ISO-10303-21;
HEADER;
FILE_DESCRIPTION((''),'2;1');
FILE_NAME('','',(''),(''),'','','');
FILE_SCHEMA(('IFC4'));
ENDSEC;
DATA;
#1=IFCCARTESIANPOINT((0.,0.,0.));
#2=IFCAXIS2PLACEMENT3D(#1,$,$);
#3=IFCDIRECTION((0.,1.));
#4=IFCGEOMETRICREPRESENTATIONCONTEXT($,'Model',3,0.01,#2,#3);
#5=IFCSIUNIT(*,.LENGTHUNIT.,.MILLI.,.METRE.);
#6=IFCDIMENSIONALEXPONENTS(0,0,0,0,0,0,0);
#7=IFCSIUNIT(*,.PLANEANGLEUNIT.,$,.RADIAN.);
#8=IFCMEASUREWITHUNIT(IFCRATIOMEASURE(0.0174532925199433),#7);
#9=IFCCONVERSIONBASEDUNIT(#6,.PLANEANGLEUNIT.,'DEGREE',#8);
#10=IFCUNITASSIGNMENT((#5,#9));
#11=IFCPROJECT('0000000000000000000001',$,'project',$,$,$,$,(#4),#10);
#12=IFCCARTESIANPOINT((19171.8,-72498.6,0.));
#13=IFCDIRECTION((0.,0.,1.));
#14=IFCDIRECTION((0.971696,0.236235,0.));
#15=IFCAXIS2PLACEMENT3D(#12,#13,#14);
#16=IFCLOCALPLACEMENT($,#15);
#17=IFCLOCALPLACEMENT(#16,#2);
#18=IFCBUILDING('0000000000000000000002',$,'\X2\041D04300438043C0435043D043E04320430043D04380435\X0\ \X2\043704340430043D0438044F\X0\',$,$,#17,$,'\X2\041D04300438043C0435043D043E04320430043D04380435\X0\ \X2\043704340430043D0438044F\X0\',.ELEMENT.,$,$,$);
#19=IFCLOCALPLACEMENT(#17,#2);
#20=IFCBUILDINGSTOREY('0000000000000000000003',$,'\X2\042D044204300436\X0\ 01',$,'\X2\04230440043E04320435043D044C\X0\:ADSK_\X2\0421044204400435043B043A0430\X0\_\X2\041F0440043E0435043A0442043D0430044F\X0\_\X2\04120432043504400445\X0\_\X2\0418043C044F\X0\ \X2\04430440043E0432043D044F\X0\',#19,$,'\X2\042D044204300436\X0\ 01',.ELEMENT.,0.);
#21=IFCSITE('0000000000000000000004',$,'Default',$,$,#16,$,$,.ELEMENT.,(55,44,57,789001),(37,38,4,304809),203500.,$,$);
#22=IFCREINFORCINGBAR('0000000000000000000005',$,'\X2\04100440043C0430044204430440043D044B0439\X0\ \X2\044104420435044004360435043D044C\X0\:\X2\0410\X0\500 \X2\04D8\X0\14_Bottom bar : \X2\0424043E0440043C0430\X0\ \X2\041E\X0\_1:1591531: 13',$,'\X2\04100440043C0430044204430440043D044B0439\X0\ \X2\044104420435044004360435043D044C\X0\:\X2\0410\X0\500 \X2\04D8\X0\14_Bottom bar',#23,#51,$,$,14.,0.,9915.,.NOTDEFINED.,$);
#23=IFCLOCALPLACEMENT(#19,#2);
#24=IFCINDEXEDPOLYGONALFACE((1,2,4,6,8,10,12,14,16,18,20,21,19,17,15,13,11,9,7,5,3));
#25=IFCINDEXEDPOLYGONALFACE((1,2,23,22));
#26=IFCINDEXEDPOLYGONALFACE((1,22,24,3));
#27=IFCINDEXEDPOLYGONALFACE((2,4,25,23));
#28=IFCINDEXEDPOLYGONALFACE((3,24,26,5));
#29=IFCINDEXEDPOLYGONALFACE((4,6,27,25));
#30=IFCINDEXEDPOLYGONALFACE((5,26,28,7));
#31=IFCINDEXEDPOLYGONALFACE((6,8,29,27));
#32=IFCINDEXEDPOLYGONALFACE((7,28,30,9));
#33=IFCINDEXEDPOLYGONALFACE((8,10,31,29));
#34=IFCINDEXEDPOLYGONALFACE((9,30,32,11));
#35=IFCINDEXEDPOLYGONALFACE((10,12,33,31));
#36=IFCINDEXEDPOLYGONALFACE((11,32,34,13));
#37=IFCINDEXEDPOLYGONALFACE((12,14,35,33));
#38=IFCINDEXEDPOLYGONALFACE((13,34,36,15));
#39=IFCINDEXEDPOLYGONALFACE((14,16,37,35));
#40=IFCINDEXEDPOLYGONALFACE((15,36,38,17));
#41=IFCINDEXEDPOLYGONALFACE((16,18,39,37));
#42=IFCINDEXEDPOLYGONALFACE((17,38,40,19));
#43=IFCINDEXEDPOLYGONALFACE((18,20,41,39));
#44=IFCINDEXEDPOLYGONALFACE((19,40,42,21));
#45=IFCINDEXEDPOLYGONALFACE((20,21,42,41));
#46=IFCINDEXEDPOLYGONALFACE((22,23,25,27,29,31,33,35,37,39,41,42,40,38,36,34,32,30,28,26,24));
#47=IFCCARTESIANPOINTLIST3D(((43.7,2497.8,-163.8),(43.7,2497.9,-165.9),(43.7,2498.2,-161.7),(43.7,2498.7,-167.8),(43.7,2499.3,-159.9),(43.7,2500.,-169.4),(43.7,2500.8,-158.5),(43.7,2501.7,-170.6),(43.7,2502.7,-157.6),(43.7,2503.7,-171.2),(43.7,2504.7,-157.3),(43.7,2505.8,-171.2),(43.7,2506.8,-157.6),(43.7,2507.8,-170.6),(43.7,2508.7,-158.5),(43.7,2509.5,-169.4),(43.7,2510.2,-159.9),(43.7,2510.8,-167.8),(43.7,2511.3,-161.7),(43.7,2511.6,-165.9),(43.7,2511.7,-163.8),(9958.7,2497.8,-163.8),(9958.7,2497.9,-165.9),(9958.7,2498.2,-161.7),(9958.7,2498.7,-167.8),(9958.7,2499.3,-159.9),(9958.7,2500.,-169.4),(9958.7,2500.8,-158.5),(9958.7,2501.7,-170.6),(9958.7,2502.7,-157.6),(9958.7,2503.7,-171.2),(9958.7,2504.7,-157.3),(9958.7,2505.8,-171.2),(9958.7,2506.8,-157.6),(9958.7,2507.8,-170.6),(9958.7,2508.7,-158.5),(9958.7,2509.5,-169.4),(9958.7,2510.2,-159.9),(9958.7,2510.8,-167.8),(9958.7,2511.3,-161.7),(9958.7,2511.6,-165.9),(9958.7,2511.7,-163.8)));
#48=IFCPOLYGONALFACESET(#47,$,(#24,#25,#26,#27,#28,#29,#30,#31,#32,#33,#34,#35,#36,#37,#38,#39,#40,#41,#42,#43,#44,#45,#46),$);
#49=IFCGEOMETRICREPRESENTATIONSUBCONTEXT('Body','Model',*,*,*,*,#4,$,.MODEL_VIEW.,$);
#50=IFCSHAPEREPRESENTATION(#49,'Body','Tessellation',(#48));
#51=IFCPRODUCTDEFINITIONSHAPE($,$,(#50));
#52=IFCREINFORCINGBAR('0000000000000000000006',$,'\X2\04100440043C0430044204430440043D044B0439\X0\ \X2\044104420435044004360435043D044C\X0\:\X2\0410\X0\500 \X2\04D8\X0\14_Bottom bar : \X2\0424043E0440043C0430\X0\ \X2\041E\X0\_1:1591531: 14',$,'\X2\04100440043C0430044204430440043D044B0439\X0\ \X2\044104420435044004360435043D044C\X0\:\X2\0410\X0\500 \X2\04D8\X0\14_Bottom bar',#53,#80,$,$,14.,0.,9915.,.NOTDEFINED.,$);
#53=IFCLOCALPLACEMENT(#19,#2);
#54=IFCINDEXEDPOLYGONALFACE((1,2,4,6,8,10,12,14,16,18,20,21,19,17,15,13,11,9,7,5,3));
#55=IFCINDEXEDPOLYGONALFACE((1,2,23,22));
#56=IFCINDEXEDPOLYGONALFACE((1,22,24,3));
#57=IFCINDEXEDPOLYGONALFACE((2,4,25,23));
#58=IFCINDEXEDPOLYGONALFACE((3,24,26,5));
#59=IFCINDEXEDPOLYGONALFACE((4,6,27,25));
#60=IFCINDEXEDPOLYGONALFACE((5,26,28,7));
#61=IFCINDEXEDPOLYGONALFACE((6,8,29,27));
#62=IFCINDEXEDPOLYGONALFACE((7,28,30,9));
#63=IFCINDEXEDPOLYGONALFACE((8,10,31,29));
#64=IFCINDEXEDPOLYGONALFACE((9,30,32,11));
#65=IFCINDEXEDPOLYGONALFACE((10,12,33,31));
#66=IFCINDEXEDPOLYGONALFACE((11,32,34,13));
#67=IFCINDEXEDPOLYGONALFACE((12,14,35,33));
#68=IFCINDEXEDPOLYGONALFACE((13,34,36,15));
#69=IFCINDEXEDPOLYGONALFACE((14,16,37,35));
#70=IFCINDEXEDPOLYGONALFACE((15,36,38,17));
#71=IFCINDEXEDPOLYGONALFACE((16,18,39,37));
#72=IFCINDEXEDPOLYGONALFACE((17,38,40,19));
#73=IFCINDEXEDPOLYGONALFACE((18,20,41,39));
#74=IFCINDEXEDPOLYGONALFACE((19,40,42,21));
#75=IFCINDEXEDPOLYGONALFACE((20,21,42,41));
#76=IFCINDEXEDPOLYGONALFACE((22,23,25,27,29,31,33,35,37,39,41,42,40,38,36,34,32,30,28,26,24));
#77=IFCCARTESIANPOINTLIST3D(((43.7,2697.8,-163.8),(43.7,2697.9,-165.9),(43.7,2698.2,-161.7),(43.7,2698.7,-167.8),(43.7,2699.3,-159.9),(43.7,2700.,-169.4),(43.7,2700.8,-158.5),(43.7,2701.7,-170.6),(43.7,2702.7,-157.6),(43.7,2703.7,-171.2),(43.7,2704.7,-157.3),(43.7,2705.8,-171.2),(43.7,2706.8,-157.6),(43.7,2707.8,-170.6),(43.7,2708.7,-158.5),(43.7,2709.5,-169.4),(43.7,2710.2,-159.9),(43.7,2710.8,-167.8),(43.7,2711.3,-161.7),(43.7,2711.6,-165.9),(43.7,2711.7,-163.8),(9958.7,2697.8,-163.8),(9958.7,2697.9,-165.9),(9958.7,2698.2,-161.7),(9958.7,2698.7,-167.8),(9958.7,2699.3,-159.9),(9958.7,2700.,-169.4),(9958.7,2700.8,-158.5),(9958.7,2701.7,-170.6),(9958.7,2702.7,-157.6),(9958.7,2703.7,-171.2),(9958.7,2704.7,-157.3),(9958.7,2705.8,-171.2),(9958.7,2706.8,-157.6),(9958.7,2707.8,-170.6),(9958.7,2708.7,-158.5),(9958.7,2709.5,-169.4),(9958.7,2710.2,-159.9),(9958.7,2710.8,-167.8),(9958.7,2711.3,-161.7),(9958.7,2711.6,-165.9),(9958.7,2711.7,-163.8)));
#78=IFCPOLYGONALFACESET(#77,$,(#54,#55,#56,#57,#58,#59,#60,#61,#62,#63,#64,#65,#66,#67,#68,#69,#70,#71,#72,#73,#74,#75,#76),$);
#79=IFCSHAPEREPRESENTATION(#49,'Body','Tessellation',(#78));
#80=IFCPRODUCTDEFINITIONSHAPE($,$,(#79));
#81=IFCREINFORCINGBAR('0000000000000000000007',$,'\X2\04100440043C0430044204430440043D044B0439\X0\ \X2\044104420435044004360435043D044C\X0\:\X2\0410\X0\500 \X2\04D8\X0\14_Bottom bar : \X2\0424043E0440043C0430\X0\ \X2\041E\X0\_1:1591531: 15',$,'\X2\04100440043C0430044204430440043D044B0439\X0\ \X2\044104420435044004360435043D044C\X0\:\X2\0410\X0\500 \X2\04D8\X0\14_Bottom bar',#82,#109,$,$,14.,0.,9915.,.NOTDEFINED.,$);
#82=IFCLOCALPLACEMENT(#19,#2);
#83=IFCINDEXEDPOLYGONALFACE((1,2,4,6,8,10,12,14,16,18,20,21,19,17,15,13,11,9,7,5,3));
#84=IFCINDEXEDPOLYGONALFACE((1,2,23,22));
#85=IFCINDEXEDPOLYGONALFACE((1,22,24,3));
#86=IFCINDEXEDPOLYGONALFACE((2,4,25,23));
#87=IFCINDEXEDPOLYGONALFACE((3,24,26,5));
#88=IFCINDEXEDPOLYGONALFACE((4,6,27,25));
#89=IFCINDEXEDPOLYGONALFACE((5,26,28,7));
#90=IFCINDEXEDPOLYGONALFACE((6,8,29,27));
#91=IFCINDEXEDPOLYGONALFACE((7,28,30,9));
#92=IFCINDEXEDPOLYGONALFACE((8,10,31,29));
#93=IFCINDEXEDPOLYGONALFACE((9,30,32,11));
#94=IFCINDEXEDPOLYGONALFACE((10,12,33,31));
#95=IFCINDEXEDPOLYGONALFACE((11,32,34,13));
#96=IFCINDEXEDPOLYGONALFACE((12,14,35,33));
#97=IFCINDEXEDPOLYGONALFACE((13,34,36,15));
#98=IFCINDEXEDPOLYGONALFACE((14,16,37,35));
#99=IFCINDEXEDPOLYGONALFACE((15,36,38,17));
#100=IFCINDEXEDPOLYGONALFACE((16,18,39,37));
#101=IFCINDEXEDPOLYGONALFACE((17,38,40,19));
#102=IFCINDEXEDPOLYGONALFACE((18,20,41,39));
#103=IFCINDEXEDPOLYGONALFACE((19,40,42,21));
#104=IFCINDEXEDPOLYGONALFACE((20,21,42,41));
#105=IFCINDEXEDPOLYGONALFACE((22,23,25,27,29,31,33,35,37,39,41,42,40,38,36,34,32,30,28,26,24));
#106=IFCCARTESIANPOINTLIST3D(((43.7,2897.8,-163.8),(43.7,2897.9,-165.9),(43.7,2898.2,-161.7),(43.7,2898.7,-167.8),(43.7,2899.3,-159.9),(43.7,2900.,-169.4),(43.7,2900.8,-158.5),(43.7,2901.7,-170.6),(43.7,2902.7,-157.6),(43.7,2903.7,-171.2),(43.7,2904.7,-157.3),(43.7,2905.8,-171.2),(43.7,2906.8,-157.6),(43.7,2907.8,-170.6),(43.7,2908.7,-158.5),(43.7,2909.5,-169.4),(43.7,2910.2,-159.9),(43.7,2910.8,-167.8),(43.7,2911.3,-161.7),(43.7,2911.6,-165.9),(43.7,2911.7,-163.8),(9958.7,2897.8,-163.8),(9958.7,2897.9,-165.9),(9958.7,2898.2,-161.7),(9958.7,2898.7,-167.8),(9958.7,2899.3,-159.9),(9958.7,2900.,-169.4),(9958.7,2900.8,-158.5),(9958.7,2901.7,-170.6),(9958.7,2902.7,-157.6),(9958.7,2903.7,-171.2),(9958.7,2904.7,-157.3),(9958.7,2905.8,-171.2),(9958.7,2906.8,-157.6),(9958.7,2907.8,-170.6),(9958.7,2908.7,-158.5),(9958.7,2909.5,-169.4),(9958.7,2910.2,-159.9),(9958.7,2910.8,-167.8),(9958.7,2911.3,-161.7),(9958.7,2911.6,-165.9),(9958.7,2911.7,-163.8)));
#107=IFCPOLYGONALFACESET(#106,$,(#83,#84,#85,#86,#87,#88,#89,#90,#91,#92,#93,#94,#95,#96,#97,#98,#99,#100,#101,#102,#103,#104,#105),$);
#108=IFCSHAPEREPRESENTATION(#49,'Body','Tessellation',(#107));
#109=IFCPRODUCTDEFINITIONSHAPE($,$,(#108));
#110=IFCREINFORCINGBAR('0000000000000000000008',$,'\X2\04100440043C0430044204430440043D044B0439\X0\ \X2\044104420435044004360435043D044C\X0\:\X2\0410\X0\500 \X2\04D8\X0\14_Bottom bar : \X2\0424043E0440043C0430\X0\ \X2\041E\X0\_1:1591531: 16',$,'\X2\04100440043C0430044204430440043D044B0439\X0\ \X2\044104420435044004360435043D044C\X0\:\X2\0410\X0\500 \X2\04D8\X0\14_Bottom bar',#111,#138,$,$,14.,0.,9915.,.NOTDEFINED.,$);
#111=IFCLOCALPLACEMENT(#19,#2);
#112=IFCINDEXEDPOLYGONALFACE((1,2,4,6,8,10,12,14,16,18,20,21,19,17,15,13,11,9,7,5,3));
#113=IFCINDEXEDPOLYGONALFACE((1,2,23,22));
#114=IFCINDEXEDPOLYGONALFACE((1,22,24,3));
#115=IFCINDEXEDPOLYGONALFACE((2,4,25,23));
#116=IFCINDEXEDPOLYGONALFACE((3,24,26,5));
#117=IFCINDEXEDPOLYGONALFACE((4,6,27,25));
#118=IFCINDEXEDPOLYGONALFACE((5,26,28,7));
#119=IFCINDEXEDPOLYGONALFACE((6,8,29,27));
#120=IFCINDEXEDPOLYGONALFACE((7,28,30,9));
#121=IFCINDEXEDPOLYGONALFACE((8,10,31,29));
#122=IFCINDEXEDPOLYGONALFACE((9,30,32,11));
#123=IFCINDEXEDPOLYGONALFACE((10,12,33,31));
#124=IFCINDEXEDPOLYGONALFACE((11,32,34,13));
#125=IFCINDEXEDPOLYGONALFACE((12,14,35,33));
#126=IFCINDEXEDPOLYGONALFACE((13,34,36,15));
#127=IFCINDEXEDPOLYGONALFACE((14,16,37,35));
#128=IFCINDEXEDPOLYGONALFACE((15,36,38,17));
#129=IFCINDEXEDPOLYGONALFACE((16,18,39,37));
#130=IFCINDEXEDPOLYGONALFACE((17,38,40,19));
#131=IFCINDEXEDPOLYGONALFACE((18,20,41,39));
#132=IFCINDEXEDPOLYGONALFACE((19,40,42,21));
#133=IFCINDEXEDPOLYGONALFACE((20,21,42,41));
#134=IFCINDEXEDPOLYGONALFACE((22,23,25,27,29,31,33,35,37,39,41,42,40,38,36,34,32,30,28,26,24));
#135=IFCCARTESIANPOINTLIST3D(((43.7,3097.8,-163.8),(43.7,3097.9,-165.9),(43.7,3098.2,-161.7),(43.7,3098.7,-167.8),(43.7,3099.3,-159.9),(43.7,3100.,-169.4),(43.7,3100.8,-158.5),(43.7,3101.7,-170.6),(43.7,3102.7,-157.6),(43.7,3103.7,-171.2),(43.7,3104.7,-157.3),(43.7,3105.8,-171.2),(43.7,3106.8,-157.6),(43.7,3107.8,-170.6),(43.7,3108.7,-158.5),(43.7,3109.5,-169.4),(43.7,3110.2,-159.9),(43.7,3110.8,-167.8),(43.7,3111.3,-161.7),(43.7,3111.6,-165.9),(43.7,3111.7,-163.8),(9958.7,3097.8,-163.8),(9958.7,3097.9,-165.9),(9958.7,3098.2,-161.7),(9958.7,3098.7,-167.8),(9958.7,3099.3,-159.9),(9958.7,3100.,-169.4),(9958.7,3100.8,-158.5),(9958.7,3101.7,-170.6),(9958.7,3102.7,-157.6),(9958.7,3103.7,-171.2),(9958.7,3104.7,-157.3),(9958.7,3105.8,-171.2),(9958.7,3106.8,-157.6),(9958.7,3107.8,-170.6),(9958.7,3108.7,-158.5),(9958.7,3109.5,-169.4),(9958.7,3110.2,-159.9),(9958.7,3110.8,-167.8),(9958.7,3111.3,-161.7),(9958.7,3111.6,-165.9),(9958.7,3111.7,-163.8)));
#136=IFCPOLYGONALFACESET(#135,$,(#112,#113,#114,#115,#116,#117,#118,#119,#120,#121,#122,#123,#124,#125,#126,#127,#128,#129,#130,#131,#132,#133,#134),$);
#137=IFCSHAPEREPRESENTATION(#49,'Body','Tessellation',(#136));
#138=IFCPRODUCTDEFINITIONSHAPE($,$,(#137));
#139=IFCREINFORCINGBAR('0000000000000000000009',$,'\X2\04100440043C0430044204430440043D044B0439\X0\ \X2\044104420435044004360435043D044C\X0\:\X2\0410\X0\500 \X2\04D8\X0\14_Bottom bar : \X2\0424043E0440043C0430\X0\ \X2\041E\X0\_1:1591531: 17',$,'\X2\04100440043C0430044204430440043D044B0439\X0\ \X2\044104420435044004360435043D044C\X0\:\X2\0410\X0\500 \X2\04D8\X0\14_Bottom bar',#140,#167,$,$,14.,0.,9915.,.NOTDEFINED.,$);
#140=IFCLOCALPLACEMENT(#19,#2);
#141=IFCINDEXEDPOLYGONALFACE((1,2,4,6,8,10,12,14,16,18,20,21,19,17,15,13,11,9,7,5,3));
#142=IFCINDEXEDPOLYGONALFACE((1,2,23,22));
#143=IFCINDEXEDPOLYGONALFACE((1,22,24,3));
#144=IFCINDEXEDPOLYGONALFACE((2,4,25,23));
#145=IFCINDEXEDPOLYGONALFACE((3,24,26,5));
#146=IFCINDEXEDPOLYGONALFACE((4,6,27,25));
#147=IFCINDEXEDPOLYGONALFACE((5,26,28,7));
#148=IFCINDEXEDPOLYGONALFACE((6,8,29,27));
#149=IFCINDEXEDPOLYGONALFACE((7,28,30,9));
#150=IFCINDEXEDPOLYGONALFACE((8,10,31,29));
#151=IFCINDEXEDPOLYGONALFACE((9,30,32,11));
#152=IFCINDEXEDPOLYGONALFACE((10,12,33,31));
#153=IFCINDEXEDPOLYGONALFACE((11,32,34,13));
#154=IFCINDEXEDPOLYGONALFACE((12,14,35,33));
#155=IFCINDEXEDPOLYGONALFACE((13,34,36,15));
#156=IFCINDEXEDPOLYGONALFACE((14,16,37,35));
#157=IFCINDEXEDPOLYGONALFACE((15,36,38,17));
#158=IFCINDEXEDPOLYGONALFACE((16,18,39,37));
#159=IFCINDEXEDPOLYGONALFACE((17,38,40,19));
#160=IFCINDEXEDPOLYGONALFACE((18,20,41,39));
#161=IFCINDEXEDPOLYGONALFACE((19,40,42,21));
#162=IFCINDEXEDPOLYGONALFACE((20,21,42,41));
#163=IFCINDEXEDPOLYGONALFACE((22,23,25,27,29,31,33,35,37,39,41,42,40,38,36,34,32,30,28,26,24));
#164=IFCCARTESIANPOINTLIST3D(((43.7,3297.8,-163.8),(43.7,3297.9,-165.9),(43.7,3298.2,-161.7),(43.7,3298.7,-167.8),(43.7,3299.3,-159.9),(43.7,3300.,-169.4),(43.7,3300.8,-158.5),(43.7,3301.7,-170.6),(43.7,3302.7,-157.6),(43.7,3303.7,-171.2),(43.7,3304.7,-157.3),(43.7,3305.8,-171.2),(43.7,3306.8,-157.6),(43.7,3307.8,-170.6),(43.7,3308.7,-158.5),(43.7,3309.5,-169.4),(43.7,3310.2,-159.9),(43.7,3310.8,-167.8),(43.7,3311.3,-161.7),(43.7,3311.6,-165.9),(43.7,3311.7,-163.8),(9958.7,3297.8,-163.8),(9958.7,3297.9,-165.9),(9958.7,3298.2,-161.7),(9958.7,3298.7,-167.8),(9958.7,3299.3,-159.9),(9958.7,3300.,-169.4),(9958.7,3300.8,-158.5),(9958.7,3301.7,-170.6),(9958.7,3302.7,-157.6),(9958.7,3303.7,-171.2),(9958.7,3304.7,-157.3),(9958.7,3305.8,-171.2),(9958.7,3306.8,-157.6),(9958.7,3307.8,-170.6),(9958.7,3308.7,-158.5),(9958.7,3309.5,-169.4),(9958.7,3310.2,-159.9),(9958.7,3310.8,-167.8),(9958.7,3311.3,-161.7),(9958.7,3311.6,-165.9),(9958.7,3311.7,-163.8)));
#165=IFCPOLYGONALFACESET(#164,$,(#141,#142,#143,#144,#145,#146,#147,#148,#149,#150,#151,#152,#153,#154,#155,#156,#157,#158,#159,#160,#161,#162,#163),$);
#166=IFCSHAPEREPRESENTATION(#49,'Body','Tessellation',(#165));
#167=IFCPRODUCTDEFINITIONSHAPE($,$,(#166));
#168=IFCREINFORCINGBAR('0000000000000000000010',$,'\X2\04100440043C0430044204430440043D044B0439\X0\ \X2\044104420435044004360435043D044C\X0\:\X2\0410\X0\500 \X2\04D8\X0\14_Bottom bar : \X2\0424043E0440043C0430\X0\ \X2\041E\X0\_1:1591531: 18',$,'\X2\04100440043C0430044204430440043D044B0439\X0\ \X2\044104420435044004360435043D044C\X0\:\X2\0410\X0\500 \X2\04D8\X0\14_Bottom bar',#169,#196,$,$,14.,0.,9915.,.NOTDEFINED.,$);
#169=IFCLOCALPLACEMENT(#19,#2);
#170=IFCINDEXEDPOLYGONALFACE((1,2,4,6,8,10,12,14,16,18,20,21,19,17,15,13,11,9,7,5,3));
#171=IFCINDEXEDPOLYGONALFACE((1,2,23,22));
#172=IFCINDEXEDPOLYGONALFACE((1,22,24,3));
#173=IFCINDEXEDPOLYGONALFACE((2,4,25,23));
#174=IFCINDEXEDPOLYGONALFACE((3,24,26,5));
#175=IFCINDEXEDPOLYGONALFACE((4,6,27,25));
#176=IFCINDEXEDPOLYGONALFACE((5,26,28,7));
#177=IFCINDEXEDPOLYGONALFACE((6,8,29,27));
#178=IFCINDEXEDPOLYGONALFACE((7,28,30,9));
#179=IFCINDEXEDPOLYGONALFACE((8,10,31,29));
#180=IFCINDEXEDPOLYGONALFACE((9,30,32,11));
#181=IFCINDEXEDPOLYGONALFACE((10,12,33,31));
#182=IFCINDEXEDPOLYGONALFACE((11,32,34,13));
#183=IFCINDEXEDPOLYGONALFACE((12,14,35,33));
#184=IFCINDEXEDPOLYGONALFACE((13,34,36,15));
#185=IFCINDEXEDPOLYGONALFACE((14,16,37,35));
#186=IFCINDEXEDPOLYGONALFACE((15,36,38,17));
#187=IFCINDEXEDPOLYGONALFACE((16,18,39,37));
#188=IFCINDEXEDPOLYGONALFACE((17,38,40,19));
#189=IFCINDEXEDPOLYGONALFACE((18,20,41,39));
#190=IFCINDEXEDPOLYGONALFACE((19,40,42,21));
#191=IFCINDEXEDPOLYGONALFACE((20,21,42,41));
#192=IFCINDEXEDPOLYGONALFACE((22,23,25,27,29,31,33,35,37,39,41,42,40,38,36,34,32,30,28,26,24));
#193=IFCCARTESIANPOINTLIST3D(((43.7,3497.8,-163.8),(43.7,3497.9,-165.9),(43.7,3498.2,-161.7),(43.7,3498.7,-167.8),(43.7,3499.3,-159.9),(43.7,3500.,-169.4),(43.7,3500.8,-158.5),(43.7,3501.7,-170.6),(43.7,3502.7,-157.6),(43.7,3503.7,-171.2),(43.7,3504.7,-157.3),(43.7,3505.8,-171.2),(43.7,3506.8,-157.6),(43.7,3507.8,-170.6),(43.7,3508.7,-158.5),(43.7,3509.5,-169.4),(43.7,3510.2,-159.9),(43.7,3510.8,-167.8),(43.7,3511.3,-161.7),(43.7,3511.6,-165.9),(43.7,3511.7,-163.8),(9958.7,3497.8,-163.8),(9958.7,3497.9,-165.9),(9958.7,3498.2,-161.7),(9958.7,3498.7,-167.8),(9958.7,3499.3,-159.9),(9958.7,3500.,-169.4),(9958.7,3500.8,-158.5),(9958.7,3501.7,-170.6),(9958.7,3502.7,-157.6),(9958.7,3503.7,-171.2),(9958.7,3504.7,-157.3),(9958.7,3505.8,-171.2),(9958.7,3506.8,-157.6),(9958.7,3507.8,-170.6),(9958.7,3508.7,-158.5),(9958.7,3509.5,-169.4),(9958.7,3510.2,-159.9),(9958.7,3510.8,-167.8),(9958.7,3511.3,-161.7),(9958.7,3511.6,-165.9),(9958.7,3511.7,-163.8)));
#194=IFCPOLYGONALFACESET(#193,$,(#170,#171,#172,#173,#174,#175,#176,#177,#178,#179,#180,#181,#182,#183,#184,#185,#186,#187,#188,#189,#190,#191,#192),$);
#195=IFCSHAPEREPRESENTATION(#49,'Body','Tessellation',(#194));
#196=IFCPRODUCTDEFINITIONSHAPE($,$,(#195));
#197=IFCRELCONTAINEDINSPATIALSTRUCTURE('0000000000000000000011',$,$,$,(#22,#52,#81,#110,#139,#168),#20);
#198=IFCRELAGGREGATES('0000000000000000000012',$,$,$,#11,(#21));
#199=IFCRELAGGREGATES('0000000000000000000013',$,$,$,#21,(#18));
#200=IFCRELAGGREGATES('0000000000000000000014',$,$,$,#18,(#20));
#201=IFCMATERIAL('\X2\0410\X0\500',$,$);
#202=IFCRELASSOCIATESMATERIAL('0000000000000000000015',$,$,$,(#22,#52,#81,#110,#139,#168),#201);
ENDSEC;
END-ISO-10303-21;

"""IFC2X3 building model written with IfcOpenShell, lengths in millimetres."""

from ifc_helpers import new_model, entity, si_unit, converted_unit, direction, frame, origin, place, context, subcontext, project, spatial, material, element, save


model = new_model("IFC2X3")

# Units and contexts
model_context = context("Model", 3, precision=0.01, world=origin(), true_north=direction((0.0, 1.0)))
body_context = subcontext(model_context, "Body", "Model", "MODEL_VIEW")
ifc_project = project(units=[si_unit("LENGTHUNIT", "METRE", prefix="MILLI"), converted_unit("PLANEANGLEUNIT", "DEGREE", entity("IfcRatioMeasure", 0.0174532925199433), si_unit("PLANEANGLEUNIT", "RADIAN"), dimensions=[0, 0, 0, 0, 0, 0, 0])], contexts=[model_context])

# Site, building, storey
site_placement = place(None, frame((19171.8, -72498.6, 0.0), z_axis=(0.0, 0.0, 1.0), x_axis=(0.971696, 0.236235, 0.0)))
site = spatial("IfcSite", under=ifc_project, at=site_placement, Name="Default", CompositionType="ELEMENT", RefLatitude=(55, 44, 57, 789001), RefLongitude=(37, 38, 4, 304809), RefElevation=203500.0)
building_placement = place(site_placement, origin())
building = spatial("IfcBuilding", under=site, at=building_placement, Name="Наименование здания", LongName="Наименование здания", CompositionType="ELEMENT")
storey_placement = place(building_placement, origin())
storey = spatial("IfcBuildingStorey", under=building, at=storey_placement, Name="Этаж 01", ObjectType="Уровень:ADSK_Стрелка_Проектная_Вверх_Имя уровня", LongName="Этаж 01", CompositionType="ELEMENT", Elevation=0.0)

# Reinforcing bars
ifc_material = material(Name="А500")
placement = place(storey_placement, origin())
element("IfcReinforcingBar", 1, at=placement, inside=storey, material=ifc_material, Name="Арматурный стержень:А500 Ә14_Bottom bar : Форма О_1:1591531: 13", ObjectType="Арматурный стержень:А500 Ә14_Bottom bar", BarLength=9915.0, BarRole="NOTDEFINED", CrossSectionArea=0.0, NominalDiameter=14.0, context=body_context, shape_type="AdvancedSweptSolid", body=[
    entity("IfcSweptDiskSolid", entity("IfcCompositeCurve", [entity("IfcCompositeCurveSegment", "CONTINUOUS", True, entity("IfcPolyline", [entity("IfcCartesianPoint", [43.7, 2504.7, -164.3]), entity("IfcCartesianPoint", [9958.7, 2504.7, -164.3])]))], False), 7.0, None, 0.0, 1.0),
])
element("IfcReinforcingBar", 2, at=placement, inside=storey, material=ifc_material, Name="Арматурный стержень:А500 Ә14_Bottom bar : Форма О_1:1591531: 14", ObjectType="Арматурный стержень:А500 Ә14_Bottom bar", BarLength=9915.0, BarRole="NOTDEFINED", CrossSectionArea=0.0, NominalDiameter=14.0, context=body_context, shape_type="AdvancedSweptSolid", body=[
    entity("IfcSweptDiskSolid", entity("IfcCompositeCurve", [entity("IfcCompositeCurveSegment", "CONTINUOUS", True, entity("IfcPolyline", [entity("IfcCartesianPoint", [43.7, 2704.7, -164.3]), entity("IfcCartesianPoint", [9958.7, 2704.7, -164.3])]))], False), 7.0, None, 0.0, 1.0),
])
element("IfcReinforcingBar", 3, at=placement, inside=storey, material=ifc_material, Name="Арматурный стержень:А500 Ә14_Bottom bar : Форма О_1:1591531: 15", ObjectType="Арматурный стержень:А500 Ә14_Bottom bar", BarLength=9915.0, BarRole="NOTDEFINED", CrossSectionArea=0.0, NominalDiameter=14.0, context=body_context, shape_type="AdvancedSweptSolid", body=[
    entity("IfcSweptDiskSolid", entity("IfcCompositeCurve", [entity("IfcCompositeCurveSegment", "CONTINUOUS", True, entity("IfcPolyline", [entity("IfcCartesianPoint", [43.7, 2904.7, -164.3]), entity("IfcCartesianPoint", [9958.7, 2904.7, -164.3])]))], False), 7.0, None, 0.0, 1.0),
])
element("IfcReinforcingBar", 4, at=placement, inside=storey, material=ifc_material, Name="Арматурный стержень:А500 Ә14_Bottom bar : Форма О_1:1591531: 16", ObjectType="Арматурный стержень:А500 Ә14_Bottom bar", BarLength=9915.0, BarRole="NOTDEFINED", CrossSectionArea=0.0, NominalDiameter=14.0, context=body_context, shape_type="AdvancedSweptSolid", body=[
    entity("IfcSweptDiskSolid", entity("IfcCompositeCurve", [entity("IfcCompositeCurveSegment", "CONTINUOUS", True, entity("IfcPolyline", [entity("IfcCartesianPoint", [43.7, 3104.7, -164.3]), entity("IfcCartesianPoint", [9958.7, 3104.7, -164.3])]))], False), 7.0, None, 0.0, 1.0),
])
element("IfcReinforcingBar", 5, at=placement, inside=storey, material=ifc_material, Name="Арматурный стержень:А500 Ә14_Bottom bar : Форма О_1:1591531: 17", ObjectType="Арматурный стержень:А500 Ә14_Bottom bar", BarLength=9915.0, BarRole="NOTDEFINED", CrossSectionArea=0.0, NominalDiameter=14.0, context=body_context, shape_type="AdvancedSweptSolid", body=[
    entity("IfcSweptDiskSolid", entity("IfcCompositeCurve", [entity("IfcCompositeCurveSegment", "CONTINUOUS", True, entity("IfcPolyline", [entity("IfcCartesianPoint", [43.7, 3304.7, -164.3]), entity("IfcCartesianPoint", [9958.7, 3304.7, -164.3])]))], False), 7.0, None, 0.0, 1.0),
])
element("IfcReinforcingBar", 6, at=placement, inside=storey, material=ifc_material, Name="Арматурный стержень:А500 Ә14_Bottom bar : Форма О_1:1591531: 18", ObjectType="Арматурный стержень:А500 Ә14_Bottom bar", BarLength=9915.0, BarRole="NOTDEFINED", CrossSectionArea=0.0, NominalDiameter=14.0, context=body_context, shape_type="AdvancedSweptSolid", body=[
    entity("IfcSweptDiskSolid", entity("IfcCompositeCurve", [entity("IfcCompositeCurveSegment", "CONTINUOUS", True, entity("IfcPolyline", [entity("IfcCartesianPoint", [43.7, 3504.7, -164.3]), entity("IfcCartesianPoint", [9958.7, 3504.7, -164.3])]))], False), 7.0, None, 0.0, 1.0),
])

save(model, "model.ifc")
